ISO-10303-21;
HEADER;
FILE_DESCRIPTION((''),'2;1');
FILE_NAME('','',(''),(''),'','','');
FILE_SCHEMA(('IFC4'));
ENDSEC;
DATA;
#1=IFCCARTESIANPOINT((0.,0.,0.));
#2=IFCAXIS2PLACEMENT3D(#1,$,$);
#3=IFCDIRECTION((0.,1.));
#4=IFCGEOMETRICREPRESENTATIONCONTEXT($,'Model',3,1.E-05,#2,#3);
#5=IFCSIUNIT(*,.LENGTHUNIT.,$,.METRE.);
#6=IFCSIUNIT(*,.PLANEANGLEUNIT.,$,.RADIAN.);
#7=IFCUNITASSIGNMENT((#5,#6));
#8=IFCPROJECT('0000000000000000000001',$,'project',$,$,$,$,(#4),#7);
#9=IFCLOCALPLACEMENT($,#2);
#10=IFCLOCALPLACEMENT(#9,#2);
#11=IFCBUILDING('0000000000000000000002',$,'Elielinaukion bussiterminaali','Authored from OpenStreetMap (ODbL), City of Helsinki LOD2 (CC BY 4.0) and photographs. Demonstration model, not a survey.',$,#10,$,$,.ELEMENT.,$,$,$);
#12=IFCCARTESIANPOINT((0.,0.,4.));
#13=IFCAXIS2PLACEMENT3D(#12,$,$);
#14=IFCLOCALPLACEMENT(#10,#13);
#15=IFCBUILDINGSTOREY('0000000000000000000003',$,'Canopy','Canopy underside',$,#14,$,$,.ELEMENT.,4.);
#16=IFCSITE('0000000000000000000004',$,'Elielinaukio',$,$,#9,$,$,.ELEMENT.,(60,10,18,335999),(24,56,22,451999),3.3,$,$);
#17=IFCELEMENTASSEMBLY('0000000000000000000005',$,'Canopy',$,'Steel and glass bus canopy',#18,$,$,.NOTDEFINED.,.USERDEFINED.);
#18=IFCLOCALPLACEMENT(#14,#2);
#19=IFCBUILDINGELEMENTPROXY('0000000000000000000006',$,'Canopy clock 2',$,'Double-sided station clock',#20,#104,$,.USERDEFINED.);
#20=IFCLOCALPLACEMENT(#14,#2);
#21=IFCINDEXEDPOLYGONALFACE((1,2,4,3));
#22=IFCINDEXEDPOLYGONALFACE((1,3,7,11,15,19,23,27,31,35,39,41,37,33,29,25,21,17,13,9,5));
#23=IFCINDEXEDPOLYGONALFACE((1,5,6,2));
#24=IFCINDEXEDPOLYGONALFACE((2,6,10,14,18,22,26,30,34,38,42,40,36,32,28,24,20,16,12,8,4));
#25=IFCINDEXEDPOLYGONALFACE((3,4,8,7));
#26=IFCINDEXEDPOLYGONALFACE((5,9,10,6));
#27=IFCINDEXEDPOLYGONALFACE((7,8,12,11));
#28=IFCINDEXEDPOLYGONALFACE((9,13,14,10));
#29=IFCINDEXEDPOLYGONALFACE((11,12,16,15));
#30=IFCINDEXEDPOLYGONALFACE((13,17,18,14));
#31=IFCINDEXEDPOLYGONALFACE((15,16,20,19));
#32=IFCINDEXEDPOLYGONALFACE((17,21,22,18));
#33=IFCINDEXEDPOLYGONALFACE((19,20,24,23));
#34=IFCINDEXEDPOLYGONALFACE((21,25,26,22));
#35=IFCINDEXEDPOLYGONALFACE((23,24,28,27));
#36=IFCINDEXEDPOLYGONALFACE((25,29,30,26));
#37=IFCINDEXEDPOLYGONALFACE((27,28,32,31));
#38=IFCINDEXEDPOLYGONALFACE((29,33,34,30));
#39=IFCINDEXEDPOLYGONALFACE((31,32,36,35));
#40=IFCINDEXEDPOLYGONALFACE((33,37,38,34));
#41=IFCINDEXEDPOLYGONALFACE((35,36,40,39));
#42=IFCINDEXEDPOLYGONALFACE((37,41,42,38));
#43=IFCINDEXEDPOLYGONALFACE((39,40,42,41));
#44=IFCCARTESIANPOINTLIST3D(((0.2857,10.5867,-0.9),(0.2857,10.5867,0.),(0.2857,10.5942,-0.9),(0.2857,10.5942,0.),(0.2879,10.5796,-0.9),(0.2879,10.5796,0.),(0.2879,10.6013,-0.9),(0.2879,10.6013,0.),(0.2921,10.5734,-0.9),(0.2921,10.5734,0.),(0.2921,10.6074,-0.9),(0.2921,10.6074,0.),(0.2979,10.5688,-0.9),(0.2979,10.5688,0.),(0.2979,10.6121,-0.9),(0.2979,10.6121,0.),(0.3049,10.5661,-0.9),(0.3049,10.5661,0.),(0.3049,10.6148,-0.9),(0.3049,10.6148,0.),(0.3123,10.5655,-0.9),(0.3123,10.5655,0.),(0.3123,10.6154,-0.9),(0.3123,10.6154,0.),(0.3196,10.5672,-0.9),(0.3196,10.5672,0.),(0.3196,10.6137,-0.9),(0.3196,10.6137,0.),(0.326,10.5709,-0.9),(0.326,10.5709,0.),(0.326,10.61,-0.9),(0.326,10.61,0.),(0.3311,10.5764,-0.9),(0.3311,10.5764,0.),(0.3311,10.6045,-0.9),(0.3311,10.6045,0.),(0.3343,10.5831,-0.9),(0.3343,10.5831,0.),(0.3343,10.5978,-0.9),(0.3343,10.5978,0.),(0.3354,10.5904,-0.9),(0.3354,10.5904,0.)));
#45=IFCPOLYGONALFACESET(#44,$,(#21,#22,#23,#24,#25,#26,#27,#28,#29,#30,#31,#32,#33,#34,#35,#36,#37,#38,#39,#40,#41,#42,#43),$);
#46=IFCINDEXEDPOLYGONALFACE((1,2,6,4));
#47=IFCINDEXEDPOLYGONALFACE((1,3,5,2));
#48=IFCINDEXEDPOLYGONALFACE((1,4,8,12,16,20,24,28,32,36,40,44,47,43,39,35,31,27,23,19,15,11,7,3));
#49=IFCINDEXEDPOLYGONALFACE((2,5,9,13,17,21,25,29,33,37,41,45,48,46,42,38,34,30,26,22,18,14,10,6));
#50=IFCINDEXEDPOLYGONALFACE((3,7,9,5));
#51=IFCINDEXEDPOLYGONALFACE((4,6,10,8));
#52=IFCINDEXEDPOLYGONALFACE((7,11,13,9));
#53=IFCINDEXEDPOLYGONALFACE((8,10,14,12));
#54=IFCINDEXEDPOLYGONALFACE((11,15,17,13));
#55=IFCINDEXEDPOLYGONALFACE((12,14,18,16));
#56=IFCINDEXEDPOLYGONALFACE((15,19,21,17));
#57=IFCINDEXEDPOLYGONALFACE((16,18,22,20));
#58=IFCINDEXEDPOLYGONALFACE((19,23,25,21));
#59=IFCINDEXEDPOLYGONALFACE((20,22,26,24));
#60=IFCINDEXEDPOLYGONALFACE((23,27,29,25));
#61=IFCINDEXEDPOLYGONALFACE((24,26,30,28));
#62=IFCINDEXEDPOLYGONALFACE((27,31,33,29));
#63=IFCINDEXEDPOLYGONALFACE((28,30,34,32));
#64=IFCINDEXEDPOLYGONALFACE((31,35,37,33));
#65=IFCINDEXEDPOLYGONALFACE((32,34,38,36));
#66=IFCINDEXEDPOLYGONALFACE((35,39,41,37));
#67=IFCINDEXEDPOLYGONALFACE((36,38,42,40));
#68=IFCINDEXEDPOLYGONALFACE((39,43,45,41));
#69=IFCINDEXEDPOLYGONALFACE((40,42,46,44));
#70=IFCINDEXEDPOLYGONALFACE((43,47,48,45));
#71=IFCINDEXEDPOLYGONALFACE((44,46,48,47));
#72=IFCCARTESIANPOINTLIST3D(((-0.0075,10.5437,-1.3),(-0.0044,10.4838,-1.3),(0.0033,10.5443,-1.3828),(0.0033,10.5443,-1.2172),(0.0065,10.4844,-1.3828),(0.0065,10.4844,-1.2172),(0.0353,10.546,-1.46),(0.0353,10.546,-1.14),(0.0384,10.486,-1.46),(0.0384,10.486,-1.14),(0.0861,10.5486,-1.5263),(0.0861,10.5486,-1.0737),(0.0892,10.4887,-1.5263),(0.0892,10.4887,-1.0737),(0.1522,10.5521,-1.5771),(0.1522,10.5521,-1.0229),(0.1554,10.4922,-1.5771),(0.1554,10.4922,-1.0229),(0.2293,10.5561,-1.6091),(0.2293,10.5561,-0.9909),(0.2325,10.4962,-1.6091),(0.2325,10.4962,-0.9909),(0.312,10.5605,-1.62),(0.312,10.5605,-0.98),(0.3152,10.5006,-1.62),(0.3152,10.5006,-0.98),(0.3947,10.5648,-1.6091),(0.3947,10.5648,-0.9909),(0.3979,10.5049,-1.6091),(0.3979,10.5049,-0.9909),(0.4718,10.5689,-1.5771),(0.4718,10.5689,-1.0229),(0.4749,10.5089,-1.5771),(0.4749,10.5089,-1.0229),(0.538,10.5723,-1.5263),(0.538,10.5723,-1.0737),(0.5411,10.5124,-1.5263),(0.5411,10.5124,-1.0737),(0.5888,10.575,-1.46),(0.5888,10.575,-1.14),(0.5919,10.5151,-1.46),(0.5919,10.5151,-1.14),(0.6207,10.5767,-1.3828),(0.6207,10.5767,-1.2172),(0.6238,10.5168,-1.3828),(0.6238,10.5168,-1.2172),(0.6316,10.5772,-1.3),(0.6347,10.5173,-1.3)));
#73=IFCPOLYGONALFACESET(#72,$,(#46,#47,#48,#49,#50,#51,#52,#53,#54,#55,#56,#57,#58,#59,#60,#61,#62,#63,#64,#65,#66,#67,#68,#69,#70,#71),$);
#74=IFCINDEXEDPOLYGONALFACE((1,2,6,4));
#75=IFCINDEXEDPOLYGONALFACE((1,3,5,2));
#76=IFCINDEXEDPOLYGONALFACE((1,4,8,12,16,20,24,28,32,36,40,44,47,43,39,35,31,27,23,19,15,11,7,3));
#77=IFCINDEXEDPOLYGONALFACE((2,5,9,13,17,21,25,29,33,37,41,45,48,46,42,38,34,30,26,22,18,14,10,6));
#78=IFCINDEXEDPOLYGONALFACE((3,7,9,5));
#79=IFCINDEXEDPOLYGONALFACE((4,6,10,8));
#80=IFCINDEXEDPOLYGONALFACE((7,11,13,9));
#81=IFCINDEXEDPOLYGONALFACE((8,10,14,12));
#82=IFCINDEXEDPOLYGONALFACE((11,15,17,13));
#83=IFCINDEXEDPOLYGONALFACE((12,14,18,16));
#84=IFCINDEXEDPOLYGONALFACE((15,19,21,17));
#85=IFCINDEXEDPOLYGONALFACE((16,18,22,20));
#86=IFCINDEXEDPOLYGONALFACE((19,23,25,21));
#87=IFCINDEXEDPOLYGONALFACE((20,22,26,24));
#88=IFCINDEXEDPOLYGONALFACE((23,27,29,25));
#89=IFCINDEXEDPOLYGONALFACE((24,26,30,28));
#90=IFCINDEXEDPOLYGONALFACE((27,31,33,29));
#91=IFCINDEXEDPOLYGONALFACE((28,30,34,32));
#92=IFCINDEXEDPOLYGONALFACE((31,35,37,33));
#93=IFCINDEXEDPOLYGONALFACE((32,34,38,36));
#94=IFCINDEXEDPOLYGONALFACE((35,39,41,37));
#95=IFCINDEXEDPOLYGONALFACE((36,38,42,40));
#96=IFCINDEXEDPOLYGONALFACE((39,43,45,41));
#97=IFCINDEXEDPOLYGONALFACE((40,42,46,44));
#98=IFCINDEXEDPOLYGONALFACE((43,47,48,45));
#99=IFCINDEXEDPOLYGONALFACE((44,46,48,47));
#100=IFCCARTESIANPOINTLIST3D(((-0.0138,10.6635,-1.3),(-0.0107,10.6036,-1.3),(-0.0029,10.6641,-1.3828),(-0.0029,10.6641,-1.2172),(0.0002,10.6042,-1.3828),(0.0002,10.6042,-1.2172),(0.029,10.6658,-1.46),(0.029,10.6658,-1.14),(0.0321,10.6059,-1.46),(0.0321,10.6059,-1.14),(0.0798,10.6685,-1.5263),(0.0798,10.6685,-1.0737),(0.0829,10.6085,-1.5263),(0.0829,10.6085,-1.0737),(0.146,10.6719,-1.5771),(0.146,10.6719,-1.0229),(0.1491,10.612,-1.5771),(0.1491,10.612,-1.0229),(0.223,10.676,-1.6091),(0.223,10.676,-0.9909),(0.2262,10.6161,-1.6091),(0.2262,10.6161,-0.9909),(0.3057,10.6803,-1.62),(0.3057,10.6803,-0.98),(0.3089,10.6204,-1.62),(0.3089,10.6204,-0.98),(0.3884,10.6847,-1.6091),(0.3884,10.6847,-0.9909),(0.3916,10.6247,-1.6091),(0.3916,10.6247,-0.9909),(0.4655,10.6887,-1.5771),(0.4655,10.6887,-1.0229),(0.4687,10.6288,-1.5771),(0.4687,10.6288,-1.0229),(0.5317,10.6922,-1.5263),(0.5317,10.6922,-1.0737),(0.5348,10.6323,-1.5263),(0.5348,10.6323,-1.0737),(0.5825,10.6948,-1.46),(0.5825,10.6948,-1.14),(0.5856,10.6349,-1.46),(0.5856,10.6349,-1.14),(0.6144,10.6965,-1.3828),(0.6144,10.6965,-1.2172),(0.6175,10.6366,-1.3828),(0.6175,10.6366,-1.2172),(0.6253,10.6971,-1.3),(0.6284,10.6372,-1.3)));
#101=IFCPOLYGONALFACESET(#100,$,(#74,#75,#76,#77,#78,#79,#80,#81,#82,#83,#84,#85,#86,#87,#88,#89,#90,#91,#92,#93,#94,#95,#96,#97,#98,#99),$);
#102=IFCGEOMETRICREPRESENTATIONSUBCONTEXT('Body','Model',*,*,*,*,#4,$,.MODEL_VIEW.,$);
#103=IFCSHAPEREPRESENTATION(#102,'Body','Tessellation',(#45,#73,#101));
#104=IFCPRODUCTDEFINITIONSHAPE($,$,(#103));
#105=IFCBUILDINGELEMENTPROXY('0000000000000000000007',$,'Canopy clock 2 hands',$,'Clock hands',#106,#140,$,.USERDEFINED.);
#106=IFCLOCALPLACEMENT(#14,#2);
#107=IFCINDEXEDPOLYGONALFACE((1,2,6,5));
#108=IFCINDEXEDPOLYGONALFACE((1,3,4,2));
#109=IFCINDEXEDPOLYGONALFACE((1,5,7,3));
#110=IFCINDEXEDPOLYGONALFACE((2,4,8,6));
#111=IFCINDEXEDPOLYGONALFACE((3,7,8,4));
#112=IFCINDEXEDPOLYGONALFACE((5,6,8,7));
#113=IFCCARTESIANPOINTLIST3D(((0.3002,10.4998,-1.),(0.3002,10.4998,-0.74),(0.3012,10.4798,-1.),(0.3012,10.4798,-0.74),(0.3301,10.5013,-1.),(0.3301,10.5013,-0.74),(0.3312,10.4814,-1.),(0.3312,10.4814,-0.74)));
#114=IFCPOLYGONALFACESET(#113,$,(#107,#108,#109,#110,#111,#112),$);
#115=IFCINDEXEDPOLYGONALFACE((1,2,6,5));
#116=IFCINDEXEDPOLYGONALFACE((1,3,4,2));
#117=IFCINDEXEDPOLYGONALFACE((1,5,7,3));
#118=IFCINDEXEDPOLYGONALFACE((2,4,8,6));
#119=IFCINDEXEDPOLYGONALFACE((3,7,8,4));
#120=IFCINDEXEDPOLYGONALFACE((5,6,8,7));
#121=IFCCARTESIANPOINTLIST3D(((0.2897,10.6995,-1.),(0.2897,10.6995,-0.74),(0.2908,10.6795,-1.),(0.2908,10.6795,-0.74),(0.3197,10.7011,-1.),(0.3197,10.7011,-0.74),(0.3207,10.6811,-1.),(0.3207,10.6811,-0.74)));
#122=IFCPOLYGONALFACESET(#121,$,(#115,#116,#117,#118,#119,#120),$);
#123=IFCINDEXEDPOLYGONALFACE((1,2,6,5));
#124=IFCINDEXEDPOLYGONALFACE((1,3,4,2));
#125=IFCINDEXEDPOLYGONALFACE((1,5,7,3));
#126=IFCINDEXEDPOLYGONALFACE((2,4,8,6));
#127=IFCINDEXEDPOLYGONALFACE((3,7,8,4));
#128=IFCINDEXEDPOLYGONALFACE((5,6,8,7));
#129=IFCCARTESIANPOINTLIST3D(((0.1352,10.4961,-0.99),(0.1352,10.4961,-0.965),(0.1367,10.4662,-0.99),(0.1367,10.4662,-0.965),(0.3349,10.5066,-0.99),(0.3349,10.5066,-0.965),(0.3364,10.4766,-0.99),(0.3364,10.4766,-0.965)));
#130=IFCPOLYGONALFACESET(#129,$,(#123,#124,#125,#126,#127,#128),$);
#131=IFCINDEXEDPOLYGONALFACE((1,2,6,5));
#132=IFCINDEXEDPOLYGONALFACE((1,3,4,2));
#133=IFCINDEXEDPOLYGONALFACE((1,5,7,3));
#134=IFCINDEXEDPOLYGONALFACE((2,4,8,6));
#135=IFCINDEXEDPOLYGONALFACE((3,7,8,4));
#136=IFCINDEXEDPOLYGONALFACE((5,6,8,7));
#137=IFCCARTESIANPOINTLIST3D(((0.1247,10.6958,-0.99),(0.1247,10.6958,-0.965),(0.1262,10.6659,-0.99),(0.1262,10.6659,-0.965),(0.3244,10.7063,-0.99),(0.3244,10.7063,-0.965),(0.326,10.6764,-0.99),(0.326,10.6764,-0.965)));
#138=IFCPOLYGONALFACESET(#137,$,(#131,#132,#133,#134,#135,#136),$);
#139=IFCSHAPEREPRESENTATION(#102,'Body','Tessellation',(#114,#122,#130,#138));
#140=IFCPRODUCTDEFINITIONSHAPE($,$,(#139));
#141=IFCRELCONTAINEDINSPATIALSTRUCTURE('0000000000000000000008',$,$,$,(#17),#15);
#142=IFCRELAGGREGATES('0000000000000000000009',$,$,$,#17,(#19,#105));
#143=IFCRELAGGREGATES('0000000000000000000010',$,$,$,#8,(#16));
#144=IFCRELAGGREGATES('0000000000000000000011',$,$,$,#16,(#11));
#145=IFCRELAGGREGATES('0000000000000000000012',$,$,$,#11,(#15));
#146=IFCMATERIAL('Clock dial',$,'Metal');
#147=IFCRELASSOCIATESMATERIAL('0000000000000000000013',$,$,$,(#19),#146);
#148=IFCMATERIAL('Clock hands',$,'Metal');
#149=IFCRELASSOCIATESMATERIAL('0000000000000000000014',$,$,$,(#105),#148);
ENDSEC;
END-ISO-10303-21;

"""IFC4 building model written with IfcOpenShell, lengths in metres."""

from ifc_helpers import new_model, si_unit, direction, frame, frame_2d, origin, origin_2d_with_axis, place, context, subcontext, project, spatial, polyline, rectangle, circle, outline, extrude, material, element, aggregate, save


model = new_model("IFC4")

# Units and contexts
model_context = context("Model", 3, precision=1e-05, world=origin(), true_north=direction((0.0, 1.0)))
body_context = subcontext(model_context, "Body", "Model", "MODEL_VIEW")
ifc_project = project(units=[si_unit("LENGTHUNIT", "METRE"), si_unit("PLANEANGLEUNIT", "RADIAN")], contexts=[model_context])

# Site, building, storey
site_placement = place(None, origin())
site = spatial("IfcSite", under=ifc_project, at=site_placement, Name="Elielinaukio", CompositionType="ELEMENT", RefLatitude=(60, 10, 18, 335999), RefLongitude=(24, 56, 22, 451999), RefElevation=3.3)
building_placement = place(site_placement, origin())
building = spatial("IfcBuilding", under=site, at=building_placement, Name="Elielinaukion bussiterminaali", Description="Authored from OpenStreetMap (ODbL), City of Helsinki LOD2 (CC BY 4.0) and photographs. Demonstration model, not a survey.", CompositionType="ELEMENT")
storey_placement = place(building_placement, frame((0.0, 0.0, 4.0)))
storey = spatial("IfcBuildingStorey", under=building, at=storey_placement, Name="Canopy", Description="Canopy underside", CompositionType="ELEMENT", Elevation=4.0)

# Element assembly, building element proxies
assembly_placement = place(building_placement, origin())
assembly = element("IfcElementAssembly", 1, at=assembly_placement, inside=storey, Name="Canopy", ObjectType="Steel and glass bus canopy", AssemblyPlace="NOTDEFINED", PredefinedType="USERDEFINED")
ifc_material_1 = material(Name="Clock dial", Category="Metal")
ifc_material_2 = material(Name="Clock hands", Category="Metal")
proxy_1_placement = place(building_placement, origin())
proxy_1 = element("IfcBuildingElementProxy", 2, at=proxy_1_placement, material=ifc_material_1, Name="Canopy clock 2", ObjectType="Double-sided station clock", PredefinedType="USERDEFINED", context=body_context, shape_type="SweptSolid", body=[
    extrude(circle(Radius=0.025, at=origin_2d_with_axis()), frame((0.3104, 10.5904, 3.1)), (0.0, 0.0, 1.0), 0.9),
    extrude(outline(polyline([(0.32, 0.0), (0.3091, 0.0828), (0.2771, 0.16), (0.2263, 0.2263), (0.16, 0.2771), (0.0828, 0.3091), (0.0, 0.32), (-0.0828, 0.3091), (-0.16, 0.2771), (-0.2263, 0.2263), (-0.2771, 0.16), (-0.3091, 0.0828), (-0.32, 0.0), (-0.3091, -0.0828), (-0.2771, -0.16), (-0.2263, -0.2263), (-0.16, -0.2771), (-0.0828, -0.3091), (0.0, -0.32), (0.0828, -0.3091), (0.16, -0.2771), (0.2263, -0.2263), (0.2771, -0.16), (0.3091, -0.0828), (0.32, 0.0)])), frame((0.3152, 10.5006, 2.7), z_axis=(-0.052408, 0.998626, 0.0), x_axis=(-0.998626, -0.052408, 0.0)), (0.0, 0.0, 1.0), 0.06),
    extrude(outline(polyline([(0.32, 0.0), (0.3091, 0.0828), (0.2771, 0.16), (0.2263, 0.2263), (0.16, 0.2771), (0.0828, 0.3091), (0.0, 0.32), (-0.0828, 0.3091), (-0.16, 0.2771), (-0.2263, 0.2263), (-0.2771, 0.16), (-0.3091, 0.0828), (-0.32, 0.0), (-0.3091, -0.0828), (-0.2771, -0.16), (-0.2263, -0.2263), (-0.16, -0.2771), (-0.0828, -0.3091), (0.0, -0.32), (0.0828, -0.3091), (0.16, -0.2771), (0.2263, -0.2263), (0.2771, -0.16), (0.3091, -0.0828), (0.32, 0.0)])), frame((0.3089, 10.6204, 2.7), z_axis=(-0.052408, 0.998626, 0.0), x_axis=(-0.998626, -0.052408, 0.0)), (0.0, 0.0, 1.0), 0.06),
])
proxy_2_placement = place(building_placement, origin())
proxy_2 = element("IfcBuildingElementProxy", 3, at=proxy_2_placement, material=ifc_material_2, Name="Canopy clock 2 hands", ObjectType="Clock hands", PredefinedType="USERDEFINED", context=body_context, shape_type="SweptSolid", body=[
    extrude(rectangle(XDim=0.03, YDim=0.02, at=frame_2d((0.0, 0.0), x_axis=(-0.998626, -0.052408))), frame((0.3157, 10.4906, 3.0)), (0.0, 0.0, 1.0), 0.26),
    extrude(rectangle(XDim=0.03, YDim=0.02, at=frame_2d((0.0, 0.0), x_axis=(-0.998626, -0.052408))), frame((0.3052, 10.6903, 3.0)), (0.0, 0.0, 1.0), 0.26),
    extrude(rectangle(XDim=0.03, YDim=0.2, at=frame_2d((0.0, 0.0), x_axis=(-0.052408, 0.998626))), frame((0.2358, 10.4864, 3.01)), (0.0, 0.0, 1.0), 0.025),
    extrude(rectangle(XDim=0.03, YDim=0.2, at=frame_2d((0.0, 0.0), x_axis=(-0.052408, 0.998626))), frame((0.2253, 10.6861, 3.01)), (0.0, 0.0, 1.0), 0.025),
])
aggregate(assembly, [proxy_1, proxy_2])

save(model, "model.ifc")
